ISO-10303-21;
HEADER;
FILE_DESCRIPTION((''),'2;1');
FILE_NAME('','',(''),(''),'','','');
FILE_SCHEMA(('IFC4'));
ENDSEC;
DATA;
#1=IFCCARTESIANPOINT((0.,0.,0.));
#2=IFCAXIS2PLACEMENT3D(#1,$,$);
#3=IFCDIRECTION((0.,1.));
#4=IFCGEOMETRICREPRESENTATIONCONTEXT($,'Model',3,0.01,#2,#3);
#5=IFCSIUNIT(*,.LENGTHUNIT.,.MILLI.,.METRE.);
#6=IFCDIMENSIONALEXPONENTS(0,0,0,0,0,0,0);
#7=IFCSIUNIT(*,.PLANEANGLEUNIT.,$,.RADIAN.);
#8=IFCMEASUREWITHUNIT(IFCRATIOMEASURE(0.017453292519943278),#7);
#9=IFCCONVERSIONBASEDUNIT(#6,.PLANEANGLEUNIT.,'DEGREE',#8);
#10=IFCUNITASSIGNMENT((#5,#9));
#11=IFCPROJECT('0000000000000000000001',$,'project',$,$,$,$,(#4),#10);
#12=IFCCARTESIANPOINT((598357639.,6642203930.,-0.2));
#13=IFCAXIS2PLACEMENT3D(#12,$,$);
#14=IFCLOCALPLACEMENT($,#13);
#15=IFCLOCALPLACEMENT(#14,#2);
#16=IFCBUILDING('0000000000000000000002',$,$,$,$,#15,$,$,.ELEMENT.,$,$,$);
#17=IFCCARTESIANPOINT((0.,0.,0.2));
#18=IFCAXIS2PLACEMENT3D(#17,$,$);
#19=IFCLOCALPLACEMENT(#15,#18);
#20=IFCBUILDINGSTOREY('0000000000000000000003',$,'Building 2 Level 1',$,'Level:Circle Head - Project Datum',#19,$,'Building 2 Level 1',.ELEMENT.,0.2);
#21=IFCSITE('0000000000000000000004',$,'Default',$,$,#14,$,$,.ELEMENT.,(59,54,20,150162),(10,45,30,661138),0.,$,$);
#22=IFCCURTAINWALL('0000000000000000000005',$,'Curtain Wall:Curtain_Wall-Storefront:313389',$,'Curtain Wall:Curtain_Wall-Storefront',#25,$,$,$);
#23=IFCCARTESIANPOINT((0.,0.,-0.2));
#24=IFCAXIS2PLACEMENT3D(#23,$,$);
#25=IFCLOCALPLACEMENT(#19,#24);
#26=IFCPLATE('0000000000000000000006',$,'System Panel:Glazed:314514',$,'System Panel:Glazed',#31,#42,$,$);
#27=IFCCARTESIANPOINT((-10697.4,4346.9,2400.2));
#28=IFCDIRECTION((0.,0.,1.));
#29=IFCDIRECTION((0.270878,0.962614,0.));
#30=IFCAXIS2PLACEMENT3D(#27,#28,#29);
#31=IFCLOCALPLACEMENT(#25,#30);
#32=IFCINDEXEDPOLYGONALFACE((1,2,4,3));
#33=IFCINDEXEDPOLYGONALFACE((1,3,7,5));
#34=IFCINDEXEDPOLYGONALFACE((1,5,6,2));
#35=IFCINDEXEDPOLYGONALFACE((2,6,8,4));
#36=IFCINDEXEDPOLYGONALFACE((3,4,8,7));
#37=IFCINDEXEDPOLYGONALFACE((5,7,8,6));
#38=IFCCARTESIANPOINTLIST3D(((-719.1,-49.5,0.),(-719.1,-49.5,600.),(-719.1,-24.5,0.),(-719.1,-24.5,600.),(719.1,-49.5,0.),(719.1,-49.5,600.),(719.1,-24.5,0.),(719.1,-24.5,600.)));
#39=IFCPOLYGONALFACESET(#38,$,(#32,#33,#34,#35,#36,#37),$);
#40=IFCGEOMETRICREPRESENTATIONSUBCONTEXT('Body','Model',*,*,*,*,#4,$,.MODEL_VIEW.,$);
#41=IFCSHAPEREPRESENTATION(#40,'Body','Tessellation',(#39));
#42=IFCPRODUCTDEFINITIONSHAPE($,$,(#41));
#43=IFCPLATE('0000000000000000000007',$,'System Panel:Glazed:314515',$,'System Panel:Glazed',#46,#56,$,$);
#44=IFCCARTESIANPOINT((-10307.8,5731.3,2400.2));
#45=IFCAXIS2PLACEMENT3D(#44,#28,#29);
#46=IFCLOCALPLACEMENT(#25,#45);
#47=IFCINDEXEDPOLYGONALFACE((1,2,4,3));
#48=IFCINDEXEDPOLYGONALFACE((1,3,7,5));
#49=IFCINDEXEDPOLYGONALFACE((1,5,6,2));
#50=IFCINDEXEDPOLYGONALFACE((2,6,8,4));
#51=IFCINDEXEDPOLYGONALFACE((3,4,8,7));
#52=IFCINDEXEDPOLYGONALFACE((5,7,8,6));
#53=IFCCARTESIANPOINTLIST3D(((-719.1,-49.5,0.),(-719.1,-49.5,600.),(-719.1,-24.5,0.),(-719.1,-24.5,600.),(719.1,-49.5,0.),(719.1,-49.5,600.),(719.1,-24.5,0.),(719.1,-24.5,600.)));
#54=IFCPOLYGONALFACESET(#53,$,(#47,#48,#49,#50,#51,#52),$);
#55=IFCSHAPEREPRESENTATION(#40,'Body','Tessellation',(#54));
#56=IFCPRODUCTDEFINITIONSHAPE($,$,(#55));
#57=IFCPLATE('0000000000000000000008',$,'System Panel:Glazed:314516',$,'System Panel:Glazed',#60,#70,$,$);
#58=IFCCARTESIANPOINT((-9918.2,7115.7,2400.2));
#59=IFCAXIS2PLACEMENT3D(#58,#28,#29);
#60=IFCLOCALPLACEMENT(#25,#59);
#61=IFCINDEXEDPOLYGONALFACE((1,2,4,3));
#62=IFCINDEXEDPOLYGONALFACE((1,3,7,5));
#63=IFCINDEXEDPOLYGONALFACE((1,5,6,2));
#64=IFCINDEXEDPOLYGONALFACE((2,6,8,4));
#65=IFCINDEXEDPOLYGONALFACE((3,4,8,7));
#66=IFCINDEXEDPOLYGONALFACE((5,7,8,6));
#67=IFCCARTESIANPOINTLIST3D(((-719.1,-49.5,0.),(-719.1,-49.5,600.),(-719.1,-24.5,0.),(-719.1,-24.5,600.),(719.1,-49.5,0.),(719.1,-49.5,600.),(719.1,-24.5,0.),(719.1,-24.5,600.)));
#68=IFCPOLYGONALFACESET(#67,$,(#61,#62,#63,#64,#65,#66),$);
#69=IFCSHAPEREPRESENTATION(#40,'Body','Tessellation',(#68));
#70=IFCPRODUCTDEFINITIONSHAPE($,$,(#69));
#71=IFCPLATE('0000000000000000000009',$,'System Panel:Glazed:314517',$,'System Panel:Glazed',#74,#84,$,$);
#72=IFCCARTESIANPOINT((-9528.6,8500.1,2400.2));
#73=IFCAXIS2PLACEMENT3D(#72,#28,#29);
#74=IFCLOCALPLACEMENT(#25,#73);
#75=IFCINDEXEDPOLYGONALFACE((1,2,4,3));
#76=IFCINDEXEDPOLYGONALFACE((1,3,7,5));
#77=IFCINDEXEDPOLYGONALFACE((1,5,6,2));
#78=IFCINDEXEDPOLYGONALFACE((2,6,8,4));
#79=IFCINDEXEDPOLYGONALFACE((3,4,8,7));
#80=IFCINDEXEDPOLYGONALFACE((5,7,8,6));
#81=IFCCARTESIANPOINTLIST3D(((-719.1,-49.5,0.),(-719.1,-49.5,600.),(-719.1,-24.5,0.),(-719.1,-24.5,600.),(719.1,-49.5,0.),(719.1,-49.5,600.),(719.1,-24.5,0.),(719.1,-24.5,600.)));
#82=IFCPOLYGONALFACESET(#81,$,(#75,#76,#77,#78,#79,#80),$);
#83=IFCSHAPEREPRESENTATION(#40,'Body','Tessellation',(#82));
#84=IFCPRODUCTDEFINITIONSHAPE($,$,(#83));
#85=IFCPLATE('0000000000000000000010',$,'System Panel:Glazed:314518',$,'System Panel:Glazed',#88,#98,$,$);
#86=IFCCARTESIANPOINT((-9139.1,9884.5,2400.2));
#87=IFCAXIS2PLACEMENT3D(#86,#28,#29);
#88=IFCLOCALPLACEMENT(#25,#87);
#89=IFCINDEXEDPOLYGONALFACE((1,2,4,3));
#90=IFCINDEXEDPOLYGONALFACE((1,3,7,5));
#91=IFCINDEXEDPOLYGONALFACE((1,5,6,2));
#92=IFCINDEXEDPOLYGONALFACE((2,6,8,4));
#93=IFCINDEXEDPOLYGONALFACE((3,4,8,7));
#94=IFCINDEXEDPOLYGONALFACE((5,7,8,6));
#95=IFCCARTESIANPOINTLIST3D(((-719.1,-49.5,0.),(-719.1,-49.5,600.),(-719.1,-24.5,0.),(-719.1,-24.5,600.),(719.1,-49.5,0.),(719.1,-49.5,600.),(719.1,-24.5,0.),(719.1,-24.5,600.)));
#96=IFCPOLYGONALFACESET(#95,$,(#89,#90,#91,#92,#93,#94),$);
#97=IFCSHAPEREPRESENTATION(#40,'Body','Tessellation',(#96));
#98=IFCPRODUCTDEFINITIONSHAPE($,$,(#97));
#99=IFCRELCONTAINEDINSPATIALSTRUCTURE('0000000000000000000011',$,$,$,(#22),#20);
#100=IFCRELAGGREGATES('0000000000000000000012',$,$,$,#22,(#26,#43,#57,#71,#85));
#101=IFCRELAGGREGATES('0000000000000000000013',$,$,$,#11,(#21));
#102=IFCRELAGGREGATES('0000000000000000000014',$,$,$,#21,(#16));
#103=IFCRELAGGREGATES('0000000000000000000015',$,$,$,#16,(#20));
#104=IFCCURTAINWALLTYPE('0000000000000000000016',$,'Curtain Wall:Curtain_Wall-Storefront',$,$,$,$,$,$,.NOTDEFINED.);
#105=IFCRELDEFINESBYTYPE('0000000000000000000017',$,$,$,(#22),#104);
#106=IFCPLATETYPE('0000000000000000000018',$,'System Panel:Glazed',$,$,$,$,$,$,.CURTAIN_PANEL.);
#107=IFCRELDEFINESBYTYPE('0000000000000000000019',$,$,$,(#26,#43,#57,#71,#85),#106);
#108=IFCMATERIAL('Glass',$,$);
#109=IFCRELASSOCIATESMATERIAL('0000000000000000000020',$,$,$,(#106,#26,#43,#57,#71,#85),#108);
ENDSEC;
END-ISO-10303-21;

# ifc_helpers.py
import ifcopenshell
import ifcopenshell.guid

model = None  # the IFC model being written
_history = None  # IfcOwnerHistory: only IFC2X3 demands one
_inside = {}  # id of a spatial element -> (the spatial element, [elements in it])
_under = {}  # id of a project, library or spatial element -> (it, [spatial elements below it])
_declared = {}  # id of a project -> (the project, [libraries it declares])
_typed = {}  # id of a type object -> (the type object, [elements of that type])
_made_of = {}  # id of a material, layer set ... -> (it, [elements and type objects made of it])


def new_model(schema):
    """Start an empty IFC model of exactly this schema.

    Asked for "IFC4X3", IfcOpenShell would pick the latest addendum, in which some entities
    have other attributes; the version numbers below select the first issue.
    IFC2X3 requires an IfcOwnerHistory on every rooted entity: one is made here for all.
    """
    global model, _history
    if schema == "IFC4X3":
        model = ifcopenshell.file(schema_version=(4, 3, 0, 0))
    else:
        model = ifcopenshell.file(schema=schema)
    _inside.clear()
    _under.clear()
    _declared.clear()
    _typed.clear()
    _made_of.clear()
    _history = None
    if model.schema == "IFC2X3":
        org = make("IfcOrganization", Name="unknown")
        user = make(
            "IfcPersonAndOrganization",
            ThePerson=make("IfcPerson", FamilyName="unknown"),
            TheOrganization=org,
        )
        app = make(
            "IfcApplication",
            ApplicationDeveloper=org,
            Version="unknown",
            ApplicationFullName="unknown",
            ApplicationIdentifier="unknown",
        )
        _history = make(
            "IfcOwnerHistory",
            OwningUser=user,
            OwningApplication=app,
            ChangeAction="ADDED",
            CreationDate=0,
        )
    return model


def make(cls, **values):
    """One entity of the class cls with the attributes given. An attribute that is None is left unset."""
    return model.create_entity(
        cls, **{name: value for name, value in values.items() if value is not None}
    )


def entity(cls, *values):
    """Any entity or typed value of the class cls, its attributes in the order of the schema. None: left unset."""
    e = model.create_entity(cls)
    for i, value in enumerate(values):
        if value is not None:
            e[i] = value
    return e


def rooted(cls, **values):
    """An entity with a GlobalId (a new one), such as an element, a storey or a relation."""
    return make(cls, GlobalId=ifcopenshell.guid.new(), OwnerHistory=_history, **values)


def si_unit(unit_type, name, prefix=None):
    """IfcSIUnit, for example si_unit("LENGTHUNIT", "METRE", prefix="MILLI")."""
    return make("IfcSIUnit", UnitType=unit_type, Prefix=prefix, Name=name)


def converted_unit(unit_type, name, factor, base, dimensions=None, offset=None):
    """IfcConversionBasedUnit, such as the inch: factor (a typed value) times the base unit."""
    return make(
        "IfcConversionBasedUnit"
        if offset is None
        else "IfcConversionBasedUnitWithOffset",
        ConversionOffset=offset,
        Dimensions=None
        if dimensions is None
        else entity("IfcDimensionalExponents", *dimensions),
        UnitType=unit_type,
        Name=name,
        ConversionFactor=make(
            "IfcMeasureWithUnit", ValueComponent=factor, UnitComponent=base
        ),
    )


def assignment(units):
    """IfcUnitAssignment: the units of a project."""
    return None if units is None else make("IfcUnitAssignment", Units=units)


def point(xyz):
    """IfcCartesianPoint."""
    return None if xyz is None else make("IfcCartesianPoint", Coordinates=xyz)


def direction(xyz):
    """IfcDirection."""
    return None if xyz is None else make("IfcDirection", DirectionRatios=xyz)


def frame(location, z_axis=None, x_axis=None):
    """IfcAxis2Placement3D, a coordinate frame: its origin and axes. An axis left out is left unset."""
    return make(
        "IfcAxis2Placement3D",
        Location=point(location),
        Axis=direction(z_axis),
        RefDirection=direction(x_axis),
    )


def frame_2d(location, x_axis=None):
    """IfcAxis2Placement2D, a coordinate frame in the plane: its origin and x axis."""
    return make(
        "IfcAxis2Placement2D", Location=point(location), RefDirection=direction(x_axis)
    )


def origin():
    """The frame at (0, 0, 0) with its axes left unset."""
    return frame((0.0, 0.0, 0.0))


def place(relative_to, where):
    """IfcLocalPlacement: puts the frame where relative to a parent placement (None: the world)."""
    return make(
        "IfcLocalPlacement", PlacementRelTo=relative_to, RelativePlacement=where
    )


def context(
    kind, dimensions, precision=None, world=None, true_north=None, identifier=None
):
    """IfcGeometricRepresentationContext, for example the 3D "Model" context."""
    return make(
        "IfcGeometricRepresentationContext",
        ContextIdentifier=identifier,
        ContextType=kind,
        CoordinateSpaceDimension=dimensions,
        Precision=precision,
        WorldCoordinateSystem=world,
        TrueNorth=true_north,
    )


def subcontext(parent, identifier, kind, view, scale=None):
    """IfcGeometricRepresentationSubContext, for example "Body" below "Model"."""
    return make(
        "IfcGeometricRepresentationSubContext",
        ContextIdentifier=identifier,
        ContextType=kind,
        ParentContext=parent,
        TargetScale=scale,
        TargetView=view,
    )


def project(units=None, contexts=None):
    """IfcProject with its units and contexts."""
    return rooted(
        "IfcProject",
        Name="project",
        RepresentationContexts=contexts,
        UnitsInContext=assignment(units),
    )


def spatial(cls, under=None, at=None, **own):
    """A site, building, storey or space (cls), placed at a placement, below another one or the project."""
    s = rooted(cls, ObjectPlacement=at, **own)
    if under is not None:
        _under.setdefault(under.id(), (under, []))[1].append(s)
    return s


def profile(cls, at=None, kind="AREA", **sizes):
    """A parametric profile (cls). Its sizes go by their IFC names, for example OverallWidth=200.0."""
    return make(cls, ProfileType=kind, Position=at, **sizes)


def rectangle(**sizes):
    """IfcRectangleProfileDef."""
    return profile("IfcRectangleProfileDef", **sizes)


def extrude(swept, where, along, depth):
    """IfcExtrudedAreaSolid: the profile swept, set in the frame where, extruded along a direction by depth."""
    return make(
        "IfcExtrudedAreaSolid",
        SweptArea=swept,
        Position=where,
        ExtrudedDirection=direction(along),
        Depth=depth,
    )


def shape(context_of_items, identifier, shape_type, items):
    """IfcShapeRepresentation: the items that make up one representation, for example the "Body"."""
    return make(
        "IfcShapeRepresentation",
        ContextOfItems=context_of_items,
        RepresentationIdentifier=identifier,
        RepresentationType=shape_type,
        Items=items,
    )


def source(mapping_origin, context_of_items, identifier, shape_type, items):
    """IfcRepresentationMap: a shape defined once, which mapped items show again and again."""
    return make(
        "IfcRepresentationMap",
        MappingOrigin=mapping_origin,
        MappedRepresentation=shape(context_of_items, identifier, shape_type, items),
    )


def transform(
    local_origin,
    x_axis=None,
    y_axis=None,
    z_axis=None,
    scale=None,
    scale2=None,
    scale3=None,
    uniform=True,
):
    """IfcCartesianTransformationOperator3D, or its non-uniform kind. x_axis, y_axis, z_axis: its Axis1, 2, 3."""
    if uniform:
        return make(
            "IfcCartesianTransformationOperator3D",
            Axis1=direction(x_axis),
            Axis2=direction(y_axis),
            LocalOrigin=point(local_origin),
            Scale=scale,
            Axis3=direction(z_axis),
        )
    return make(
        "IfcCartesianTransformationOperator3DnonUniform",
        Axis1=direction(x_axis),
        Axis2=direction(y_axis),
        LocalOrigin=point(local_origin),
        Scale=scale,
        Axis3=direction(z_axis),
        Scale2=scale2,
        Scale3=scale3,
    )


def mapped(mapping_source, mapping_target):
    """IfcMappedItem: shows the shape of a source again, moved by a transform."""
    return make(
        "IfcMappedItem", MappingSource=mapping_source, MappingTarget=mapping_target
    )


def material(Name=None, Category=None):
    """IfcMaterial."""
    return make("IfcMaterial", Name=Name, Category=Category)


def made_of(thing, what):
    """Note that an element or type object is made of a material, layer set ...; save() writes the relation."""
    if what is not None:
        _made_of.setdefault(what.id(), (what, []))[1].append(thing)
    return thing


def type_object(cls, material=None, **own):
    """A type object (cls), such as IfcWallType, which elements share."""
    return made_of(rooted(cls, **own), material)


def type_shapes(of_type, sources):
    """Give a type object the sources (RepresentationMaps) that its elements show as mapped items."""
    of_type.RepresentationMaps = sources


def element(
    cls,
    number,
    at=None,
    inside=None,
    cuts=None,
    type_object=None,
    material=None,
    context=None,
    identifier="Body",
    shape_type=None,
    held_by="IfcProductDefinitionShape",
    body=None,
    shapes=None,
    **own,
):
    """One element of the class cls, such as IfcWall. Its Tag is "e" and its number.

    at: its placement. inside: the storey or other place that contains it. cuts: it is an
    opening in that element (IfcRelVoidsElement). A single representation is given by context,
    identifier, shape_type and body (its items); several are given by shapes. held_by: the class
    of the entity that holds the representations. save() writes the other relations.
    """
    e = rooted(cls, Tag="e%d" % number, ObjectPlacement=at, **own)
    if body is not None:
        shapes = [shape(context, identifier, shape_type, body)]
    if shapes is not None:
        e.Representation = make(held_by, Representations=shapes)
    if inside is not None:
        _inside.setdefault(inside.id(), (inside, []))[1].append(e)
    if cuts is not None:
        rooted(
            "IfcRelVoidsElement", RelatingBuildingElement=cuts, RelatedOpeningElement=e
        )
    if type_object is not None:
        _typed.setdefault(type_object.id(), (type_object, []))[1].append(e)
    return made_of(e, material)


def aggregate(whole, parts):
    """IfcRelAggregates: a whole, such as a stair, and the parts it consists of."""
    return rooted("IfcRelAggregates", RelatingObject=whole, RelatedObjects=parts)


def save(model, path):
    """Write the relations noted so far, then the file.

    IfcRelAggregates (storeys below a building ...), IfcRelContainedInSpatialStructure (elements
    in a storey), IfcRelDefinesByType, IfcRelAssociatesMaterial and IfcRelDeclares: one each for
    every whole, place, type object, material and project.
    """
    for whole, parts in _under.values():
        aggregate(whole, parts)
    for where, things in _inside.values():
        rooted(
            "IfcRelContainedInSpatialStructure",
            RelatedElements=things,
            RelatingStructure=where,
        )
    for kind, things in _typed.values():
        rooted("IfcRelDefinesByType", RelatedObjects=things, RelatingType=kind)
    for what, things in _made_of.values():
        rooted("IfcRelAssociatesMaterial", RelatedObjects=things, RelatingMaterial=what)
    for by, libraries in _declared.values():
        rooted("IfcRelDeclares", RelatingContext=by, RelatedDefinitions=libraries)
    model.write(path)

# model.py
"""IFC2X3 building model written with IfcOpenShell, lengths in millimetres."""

from ifc_helpers import new_model, entity, si_unit, converted_unit, direction, frame, frame_2d, origin, place, context, subcontext, project, spatial, rectangle, extrude, source, transform, mapped, material, type_object, type_shapes, element, aggregate, save


model = new_model("IFC2X3")

# Units and contexts
model_context = context("Model", 3, precision=0.01, world=origin(), true_north=direction((0.0, 1.0)))
body_context = subcontext(model_context, "Body", "Model", "MODEL_VIEW")
ifc_project = project(units=[si_unit("LENGTHUNIT", "METRE", prefix="MILLI"), converted_unit("PLANEANGLEUNIT", "DEGREE", entity("IfcRatioMeasure", 0.017453292519943278), si_unit("PLANEANGLEUNIT", "RADIAN"), dimensions=[0, 0, 0, 0, 0, 0, 0])], contexts=[model_context])

# Site, building, storey
site_placement = place(None, frame((598357639.0, 6642203930.0, -0.2)))
site = spatial("IfcSite", under=ifc_project, at=site_placement, Name="Default", CompositionType="ELEMENT", RefLatitude=(59, 54, 20, 150162), RefLongitude=(10, 45, 30, 661138), RefElevation=0.0)
building_placement = place(site_placement, origin())
building = spatial("IfcBuilding", under=site, at=building_placement, CompositionType="ELEMENT")
storey_placement = place(building_placement, frame((0.0, 0.0, 0.2)))
storey = spatial("IfcBuildingStorey", under=building, at=storey_placement, Name="Building 2 Level 1", ObjectType="Level:Circle Head - Project Datum", LongName="Building 2 Level 1", CompositionType="ELEMENT", Elevation=0.2)

# Curtain wall, plates
curtain_wall_type = type_object("IfcCurtainWallType", Name="Curtain Wall:Curtain_Wall-Storefront", PredefinedType="NOTDEFINED")
ifc_material = material(Name="Glass")
curtain_wall_1_placement = place(storey_placement, frame((0.0, 0.0, -0.2)))
curtain_wall_1 = element("IfcCurtainWall", 1, at=curtain_wall_1_placement, inside=storey, type_object=curtain_wall_type, Name="Curtain Wall:Curtain_Wall-Storefront:313389", ObjectType="Curtain Wall:Curtain_Wall-Storefront")
plate_type_1 = type_object("IfcPlateType", Name="System Panel:Glazed", PredefinedType="CURTAIN_PANEL", material=ifc_material)
shared_shape_1 = source(origin(), body_context, "Body", "SweptSolid", [
    extrude(rectangle(XDim=25.0, YDim=1438.2, at=frame_2d((0.0, 0.0), x_axis=(1.0, 0.0))), frame((0.0, -37.0, 0.0), z_axis=(0.0, 0.0, 1.0), x_axis=(0.0, 1.0, 0.0)), (0.0, 0.0, 1.0), 600.0),
])
type_shapes(plate_type_1, [shared_shape_1])
plate_1_placement = place(curtain_wall_1_placement, frame((-10697.4, 4346.9, 2400.2), z_axis=(0.0, 0.0, 1.0), x_axis=(0.270878, 0.962614, 0.0)))
plate_1 = element("IfcPlate", 2, at=plate_1_placement, type_object=plate_type_1, material=ifc_material, Name="System Panel:Glazed:314514", ObjectType="System Panel:Glazed", context=body_context, shape_type="MappedRepresentation", body=[
    mapped(shared_shape_1, transform((0.0, 0.0, 0.0), scale=1.0)),
])
plate_2_placement = place(curtain_wall_1_placement, frame((-10307.8, 5731.3, 2400.2), z_axis=(0.0, 0.0, 1.0), x_axis=(0.270878, 0.962614, 0.0)))
plate_2 = element("IfcPlate", 3, at=plate_2_placement, type_object=plate_type_1, material=ifc_material, Name="System Panel:Glazed:314515", ObjectType="System Panel:Glazed", context=body_context, shape_type="MappedRepresentation", body=[
    mapped(shared_shape_1, transform((0.0, 0.0, 0.0), scale=1.0)),
])
plate_3_placement = place(curtain_wall_1_placement, frame((-9918.2, 7115.7, 2400.2), z_axis=(0.0, 0.0, 1.0), x_axis=(0.270878, 0.962614, 0.0)))
plate_3 = element("IfcPlate", 4, at=plate_3_placement, type_object=plate_type_1, material=ifc_material, Name="System Panel:Glazed:314516", ObjectType="System Panel:Glazed", context=body_context, shape_type="MappedRepresentation", body=[
    mapped(shared_shape_1, transform((0.0, 0.0, 0.0), scale=1.0)),
])
plate_4_placement = place(curtain_wall_1_placement, frame((-9528.6, 8500.1, 2400.2), z_axis=(0.0, 0.0, 1.0), x_axis=(0.270878, 0.962614, 0.0)))
plate_4 = element("IfcPlate", 5, at=plate_4_placement, type_object=plate_type_1, material=ifc_material, Name="System Panel:Glazed:314517", ObjectType="System Panel:Glazed", context=body_context, shape_type="MappedRepresentation", body=[
    mapped(shared_shape_1, transform((0.0, 0.0, 0.0), scale=1.0)),
])
plate_5_placement = place(curtain_wall_1_placement, frame((-9139.1, 9884.5, 2400.2), z_axis=(0.0, 0.0, 1.0), x_axis=(0.270878, 0.962614, 0.0)))
plate_5 = element("IfcPlate", 6, at=plate_5_placement, type_object=plate_type_1, material=ifc_material, Name="System Panel:Glazed:314518", ObjectType="System Panel:Glazed", context=body_context, shape_type="MappedRepresentation", body=[
    mapped(shared_shape_1, transform((0.0, 0.0, 0.0), scale=1.0)),
])
aggregate(curtain_wall_1, [plate_1, plate_2, plate_3, plate_4, plate_5])

save(model, "model.ifc")
